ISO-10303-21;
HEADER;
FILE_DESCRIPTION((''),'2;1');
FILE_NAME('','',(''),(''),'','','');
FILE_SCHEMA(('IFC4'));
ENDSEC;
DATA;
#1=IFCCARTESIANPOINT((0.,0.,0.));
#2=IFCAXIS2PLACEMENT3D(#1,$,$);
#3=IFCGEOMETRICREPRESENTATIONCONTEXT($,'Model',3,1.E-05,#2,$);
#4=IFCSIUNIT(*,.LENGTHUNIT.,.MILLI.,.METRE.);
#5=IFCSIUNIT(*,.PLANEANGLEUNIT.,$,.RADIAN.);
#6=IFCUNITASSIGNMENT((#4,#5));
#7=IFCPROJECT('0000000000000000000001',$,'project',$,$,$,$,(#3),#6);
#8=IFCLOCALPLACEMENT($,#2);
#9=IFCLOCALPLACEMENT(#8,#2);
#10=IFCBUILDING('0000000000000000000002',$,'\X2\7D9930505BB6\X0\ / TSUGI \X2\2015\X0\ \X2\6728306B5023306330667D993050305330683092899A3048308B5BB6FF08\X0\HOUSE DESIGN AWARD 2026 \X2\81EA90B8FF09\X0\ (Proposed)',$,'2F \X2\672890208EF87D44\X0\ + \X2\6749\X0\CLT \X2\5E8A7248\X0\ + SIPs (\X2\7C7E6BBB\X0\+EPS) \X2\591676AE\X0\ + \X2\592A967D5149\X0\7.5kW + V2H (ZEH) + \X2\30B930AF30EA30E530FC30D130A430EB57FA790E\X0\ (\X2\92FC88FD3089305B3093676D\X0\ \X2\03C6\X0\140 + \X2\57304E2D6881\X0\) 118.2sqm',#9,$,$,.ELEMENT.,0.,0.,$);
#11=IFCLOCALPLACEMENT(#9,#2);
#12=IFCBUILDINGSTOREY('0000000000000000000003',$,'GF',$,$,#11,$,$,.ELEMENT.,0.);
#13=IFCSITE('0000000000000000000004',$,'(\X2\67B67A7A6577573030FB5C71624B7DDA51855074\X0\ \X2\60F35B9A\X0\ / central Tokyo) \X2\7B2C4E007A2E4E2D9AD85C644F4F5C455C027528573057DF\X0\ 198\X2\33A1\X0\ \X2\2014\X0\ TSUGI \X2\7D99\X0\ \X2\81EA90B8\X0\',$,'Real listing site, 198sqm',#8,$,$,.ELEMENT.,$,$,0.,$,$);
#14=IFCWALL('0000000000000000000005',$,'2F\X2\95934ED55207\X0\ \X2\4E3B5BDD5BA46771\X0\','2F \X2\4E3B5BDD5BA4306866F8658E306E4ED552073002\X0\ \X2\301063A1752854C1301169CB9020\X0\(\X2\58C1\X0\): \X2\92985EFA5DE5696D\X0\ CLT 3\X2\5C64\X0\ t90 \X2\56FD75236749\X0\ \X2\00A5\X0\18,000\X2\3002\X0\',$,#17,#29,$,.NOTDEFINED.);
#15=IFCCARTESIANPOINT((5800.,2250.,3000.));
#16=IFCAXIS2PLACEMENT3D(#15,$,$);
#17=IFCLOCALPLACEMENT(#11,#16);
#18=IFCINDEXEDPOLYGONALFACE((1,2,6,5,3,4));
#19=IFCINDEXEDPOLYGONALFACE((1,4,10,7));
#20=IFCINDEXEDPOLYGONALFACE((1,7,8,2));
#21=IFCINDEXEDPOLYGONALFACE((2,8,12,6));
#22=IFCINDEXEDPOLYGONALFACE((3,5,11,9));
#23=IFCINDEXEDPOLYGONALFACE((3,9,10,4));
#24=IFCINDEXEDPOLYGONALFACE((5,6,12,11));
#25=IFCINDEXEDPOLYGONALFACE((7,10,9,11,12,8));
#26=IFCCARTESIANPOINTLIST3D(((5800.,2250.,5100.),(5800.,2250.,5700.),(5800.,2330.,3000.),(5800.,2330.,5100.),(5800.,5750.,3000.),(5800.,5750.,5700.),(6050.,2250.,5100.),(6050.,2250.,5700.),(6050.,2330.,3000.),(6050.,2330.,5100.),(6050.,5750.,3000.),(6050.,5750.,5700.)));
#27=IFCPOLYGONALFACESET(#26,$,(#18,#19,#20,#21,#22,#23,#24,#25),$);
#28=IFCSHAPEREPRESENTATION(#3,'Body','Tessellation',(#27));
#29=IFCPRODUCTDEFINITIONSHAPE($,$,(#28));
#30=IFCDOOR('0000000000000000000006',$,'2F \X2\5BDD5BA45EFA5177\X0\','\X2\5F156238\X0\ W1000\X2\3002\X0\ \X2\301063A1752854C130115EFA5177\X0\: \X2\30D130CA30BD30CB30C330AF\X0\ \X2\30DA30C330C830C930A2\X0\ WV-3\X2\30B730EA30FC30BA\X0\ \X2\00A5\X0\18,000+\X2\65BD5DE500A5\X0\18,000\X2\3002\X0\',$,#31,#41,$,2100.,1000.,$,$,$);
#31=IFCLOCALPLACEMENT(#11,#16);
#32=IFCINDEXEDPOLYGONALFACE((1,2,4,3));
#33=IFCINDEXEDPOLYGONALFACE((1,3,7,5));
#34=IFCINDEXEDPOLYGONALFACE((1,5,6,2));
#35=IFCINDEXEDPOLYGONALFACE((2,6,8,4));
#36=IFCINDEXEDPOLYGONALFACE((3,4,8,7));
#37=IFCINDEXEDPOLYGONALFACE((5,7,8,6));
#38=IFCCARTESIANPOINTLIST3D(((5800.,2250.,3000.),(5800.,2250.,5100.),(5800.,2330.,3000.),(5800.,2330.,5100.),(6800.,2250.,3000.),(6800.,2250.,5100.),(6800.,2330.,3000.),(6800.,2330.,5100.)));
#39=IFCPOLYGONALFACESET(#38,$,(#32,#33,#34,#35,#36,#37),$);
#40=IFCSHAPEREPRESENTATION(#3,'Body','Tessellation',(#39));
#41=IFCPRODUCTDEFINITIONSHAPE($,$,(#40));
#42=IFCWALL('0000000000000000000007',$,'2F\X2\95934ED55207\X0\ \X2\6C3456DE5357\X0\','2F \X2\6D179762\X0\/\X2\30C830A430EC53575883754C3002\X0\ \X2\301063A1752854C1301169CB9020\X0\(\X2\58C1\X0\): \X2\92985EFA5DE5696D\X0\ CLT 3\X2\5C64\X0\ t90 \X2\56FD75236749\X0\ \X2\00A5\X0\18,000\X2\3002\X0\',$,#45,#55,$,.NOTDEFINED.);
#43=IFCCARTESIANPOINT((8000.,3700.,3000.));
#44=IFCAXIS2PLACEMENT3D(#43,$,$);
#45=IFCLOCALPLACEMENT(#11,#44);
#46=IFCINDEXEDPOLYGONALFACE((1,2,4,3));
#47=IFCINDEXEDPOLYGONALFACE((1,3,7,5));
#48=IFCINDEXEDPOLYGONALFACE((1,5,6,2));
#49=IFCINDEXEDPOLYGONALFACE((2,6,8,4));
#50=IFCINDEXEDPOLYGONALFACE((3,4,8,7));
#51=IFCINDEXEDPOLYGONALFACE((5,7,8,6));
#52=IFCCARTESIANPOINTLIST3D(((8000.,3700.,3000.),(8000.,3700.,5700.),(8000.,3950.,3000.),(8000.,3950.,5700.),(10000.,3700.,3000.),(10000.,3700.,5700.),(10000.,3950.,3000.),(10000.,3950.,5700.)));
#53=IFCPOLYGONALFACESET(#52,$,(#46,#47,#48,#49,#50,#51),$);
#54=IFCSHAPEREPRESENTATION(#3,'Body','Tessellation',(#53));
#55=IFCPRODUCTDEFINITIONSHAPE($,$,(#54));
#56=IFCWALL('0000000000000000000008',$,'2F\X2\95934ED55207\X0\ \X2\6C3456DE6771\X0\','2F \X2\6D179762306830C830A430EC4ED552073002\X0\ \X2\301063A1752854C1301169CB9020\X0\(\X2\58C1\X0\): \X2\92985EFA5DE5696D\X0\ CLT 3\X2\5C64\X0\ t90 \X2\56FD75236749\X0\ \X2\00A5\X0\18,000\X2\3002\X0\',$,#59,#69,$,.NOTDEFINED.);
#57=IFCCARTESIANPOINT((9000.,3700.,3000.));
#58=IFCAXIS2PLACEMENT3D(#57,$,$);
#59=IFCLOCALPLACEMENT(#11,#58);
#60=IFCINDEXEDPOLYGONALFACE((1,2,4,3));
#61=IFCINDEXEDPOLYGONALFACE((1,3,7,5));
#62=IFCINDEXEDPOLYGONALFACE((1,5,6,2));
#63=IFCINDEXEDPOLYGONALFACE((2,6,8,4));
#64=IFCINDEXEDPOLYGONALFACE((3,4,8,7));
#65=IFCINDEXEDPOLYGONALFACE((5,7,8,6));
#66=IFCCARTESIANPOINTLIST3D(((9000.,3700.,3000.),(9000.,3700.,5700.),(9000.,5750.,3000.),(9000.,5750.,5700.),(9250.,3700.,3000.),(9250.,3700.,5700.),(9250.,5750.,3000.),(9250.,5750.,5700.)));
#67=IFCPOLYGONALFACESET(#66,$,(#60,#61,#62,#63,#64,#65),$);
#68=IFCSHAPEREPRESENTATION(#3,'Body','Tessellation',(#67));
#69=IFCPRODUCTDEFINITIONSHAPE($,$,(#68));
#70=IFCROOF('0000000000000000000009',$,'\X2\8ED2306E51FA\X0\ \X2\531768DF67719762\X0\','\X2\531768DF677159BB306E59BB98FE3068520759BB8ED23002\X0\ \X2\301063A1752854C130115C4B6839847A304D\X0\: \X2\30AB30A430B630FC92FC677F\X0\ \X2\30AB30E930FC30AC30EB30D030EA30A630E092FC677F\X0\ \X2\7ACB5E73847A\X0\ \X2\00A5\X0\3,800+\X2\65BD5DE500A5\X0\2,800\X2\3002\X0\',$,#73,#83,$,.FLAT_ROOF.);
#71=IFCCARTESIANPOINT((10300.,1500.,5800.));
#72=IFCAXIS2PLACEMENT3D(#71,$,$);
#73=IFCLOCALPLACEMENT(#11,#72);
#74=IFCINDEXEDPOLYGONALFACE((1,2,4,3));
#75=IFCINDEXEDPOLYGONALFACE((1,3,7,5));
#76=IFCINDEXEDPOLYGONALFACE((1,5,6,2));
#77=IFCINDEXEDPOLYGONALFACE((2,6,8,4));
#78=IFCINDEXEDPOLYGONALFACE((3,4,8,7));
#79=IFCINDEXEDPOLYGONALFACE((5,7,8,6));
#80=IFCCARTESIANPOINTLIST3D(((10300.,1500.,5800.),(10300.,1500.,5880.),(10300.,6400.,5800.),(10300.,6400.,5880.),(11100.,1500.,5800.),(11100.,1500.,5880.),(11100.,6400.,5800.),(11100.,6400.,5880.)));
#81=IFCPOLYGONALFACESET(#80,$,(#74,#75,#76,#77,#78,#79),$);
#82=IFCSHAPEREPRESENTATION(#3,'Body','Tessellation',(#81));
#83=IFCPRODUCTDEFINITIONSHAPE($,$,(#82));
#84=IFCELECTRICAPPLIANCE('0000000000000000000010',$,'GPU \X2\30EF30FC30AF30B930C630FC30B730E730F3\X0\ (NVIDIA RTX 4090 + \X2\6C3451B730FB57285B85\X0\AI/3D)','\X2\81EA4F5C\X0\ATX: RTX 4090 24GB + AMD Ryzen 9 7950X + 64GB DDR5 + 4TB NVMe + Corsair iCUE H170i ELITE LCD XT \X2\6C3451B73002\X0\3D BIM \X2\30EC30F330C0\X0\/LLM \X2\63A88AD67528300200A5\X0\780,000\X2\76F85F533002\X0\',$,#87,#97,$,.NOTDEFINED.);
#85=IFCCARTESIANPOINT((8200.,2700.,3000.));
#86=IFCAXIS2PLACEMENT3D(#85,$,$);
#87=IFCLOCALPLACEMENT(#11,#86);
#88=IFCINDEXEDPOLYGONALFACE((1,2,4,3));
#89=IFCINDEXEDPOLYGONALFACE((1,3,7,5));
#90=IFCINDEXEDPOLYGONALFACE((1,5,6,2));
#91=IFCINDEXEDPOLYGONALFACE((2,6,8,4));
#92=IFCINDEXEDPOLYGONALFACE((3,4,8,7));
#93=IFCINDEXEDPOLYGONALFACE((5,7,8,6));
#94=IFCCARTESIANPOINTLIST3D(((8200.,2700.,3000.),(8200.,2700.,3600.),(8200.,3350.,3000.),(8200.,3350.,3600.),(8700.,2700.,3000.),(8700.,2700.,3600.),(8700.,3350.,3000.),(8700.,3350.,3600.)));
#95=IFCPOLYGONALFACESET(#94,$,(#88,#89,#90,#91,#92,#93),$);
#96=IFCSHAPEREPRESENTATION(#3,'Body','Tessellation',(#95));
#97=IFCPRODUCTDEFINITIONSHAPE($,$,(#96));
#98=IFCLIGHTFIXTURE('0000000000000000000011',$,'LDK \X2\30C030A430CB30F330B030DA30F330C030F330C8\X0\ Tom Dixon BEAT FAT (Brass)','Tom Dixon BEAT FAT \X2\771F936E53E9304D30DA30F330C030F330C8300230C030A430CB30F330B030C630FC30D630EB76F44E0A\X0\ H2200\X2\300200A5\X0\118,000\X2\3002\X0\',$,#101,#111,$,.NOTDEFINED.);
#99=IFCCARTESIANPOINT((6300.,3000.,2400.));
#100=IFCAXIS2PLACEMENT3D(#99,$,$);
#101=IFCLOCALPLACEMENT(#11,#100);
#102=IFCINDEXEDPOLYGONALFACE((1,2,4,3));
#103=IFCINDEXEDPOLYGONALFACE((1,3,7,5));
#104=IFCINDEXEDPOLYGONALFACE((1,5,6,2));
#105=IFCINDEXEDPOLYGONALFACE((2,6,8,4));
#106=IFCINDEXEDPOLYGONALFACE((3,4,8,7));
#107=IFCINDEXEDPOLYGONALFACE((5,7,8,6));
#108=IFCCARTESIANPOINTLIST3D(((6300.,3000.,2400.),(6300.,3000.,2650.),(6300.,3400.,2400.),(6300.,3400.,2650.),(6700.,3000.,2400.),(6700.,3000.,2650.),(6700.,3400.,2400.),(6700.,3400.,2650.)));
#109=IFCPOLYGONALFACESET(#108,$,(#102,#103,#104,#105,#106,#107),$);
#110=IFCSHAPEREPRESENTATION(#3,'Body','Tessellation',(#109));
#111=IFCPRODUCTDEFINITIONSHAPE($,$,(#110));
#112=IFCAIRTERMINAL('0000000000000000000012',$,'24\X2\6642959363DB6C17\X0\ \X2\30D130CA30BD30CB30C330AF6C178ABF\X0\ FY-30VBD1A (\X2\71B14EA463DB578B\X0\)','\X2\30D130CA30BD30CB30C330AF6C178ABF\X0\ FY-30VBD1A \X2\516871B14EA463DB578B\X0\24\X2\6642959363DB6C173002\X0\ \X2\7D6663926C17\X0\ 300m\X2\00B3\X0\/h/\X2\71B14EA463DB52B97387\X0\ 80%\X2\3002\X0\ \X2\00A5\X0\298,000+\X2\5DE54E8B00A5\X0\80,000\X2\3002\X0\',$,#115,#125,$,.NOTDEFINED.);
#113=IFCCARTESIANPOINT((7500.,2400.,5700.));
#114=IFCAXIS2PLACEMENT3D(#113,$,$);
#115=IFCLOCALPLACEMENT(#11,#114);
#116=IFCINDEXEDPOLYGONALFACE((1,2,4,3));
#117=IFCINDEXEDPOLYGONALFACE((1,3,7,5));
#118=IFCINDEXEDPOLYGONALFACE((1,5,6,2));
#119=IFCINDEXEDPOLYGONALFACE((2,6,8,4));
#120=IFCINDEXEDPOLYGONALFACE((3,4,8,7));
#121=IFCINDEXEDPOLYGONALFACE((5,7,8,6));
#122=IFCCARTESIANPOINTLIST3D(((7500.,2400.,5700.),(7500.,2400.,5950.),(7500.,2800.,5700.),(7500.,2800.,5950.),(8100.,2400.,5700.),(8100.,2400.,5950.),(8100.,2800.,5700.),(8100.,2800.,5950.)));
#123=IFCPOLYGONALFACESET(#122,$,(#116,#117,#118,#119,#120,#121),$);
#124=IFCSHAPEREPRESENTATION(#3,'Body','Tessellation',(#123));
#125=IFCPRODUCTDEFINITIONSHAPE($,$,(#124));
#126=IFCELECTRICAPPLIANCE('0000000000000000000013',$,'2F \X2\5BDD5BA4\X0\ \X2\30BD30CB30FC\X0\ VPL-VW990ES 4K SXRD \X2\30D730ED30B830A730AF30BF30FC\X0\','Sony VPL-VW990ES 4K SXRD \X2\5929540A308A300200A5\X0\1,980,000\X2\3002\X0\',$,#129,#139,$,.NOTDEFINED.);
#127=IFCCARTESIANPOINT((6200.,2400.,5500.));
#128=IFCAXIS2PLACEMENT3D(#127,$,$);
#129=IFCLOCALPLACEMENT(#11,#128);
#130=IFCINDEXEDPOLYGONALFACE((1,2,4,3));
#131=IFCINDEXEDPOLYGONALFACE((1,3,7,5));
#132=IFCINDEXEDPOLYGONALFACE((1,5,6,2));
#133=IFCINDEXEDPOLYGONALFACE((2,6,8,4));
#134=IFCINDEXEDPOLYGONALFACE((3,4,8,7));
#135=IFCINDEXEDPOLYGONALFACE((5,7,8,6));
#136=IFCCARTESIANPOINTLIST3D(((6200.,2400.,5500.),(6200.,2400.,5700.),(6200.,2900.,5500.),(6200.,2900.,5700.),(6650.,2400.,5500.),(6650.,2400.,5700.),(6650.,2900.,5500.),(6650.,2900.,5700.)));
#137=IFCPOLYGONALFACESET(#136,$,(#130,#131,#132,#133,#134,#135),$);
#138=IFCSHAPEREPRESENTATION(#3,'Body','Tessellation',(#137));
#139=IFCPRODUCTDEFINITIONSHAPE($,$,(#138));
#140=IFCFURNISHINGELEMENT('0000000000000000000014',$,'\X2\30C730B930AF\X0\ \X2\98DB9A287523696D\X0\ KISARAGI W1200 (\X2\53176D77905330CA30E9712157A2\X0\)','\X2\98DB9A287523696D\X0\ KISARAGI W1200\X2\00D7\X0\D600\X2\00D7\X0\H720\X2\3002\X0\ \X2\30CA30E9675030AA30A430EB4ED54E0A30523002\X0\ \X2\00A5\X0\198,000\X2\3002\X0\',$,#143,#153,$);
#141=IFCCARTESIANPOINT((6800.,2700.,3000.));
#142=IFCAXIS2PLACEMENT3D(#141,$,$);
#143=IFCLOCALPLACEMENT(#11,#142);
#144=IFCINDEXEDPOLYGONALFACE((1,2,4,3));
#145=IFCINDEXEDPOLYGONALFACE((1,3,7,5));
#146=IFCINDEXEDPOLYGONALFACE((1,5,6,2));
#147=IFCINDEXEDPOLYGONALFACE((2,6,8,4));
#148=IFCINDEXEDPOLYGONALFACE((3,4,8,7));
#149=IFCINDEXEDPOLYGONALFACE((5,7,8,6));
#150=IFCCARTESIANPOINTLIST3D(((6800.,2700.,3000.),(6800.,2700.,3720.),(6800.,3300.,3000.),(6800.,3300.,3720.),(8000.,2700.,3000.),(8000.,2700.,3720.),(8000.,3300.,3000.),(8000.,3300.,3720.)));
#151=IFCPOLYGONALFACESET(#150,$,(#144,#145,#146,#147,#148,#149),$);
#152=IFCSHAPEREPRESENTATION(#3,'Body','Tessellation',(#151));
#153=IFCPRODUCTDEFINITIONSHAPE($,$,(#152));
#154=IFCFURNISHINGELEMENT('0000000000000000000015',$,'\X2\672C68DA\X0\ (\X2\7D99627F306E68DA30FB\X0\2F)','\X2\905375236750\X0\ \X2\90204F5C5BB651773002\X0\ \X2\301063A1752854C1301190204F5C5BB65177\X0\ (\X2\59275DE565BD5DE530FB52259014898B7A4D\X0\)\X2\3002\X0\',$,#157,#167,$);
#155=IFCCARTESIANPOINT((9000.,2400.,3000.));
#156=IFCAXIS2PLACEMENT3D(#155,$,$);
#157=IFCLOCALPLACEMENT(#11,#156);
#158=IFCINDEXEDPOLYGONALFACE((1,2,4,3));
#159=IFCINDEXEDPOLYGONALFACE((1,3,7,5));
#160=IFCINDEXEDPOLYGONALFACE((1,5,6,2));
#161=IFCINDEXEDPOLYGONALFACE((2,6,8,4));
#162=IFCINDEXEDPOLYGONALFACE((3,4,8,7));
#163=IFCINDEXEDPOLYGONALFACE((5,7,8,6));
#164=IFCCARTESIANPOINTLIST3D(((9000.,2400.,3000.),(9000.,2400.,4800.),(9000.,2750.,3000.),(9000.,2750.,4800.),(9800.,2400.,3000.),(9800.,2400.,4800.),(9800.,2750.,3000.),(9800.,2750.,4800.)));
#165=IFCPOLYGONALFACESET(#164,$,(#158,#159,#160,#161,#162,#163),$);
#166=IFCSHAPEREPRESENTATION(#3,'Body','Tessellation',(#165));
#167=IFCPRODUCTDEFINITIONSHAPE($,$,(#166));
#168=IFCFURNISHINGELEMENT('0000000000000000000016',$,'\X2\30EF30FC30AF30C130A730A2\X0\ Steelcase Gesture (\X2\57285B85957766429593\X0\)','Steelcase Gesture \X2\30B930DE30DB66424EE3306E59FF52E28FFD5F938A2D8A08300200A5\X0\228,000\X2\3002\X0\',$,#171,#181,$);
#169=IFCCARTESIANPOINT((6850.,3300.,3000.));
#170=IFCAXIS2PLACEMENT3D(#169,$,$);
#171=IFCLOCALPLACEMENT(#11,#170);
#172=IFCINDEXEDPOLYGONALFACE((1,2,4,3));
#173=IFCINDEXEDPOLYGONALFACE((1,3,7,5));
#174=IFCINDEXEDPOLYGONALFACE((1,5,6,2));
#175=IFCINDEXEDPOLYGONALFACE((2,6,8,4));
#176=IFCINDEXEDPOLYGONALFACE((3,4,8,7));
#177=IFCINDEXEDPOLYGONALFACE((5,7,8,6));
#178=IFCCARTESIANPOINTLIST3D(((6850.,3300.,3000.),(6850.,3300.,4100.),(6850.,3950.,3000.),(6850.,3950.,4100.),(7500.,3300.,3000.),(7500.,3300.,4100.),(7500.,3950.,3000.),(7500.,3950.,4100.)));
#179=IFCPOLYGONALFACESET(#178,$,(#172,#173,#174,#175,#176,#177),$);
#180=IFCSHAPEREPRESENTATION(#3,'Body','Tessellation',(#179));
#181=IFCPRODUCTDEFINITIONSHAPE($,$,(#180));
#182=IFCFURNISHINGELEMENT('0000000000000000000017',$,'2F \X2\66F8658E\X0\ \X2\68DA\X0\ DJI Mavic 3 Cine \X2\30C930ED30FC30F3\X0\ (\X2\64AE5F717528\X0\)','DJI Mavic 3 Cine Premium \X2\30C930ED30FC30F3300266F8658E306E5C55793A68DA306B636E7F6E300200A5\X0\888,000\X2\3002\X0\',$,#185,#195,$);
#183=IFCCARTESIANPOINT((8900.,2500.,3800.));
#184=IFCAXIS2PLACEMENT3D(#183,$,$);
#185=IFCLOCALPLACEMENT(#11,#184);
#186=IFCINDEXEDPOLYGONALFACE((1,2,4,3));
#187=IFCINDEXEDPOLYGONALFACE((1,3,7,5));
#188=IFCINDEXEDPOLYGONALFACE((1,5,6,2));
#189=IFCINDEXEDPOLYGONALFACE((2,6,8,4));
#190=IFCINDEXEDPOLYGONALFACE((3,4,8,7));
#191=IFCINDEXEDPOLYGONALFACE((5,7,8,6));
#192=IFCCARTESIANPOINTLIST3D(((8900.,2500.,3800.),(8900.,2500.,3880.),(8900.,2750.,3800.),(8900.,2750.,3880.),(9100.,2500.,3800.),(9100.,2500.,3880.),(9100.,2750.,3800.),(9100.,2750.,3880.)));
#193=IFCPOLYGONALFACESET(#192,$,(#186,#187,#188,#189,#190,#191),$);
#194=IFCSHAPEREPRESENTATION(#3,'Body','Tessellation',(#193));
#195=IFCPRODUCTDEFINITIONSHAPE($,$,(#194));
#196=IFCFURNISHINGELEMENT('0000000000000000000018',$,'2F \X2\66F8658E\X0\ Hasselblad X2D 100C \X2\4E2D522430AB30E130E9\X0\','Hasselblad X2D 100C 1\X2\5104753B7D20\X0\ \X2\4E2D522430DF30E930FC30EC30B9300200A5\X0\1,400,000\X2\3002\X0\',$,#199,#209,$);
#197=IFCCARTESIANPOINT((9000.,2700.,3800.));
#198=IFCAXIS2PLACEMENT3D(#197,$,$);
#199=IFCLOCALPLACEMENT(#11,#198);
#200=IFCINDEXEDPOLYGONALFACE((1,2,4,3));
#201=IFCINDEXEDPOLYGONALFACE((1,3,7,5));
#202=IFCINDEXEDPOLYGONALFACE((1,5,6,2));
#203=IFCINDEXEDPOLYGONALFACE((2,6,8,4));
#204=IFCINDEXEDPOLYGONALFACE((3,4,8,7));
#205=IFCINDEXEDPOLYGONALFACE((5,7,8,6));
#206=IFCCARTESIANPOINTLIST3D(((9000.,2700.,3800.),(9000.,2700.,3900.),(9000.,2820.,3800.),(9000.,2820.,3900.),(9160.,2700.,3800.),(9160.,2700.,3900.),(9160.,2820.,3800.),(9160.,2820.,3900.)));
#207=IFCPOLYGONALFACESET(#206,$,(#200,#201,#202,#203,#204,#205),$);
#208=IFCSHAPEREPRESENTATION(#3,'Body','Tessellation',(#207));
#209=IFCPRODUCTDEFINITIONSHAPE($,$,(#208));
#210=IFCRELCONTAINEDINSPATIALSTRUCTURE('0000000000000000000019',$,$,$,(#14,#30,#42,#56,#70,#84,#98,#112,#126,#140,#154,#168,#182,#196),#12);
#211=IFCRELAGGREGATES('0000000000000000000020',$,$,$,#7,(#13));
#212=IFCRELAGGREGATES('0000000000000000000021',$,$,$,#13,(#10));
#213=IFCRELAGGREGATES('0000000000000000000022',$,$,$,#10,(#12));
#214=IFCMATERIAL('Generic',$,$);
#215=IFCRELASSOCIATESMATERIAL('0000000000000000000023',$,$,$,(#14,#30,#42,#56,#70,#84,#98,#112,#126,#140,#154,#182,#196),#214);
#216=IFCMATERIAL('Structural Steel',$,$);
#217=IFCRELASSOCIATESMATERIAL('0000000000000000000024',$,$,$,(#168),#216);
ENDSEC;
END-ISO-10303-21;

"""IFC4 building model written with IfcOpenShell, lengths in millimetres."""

from ifc_helpers import new_model, si_unit, frame, frame_2d, origin, place, context, project, spatial, rectangle, extrude, material, element, fill, save


model = new_model("IFC4")

# Units and contexts
model_context = context("Model", 3, precision=1e-05, world=origin())
ifc_project = project(units=[si_unit("LENGTHUNIT", "METRE", prefix="MILLI"), si_unit("PLANEANGLEUNIT", "RADIAN")], contexts=[model_context])

# Site, building, storey
site_placement = place(None, origin())
site = spatial("IfcSite", under=ifc_project, at=site_placement, Name="(架空敷地・山手線内側 想定 / central Tokyo) 第一種中高層住居専用地域 198㎡ — TSUGI 継 自邸", ObjectType="Real listing site, 198sqm", CompositionType="ELEMENT", RefElevation=0.0)
building_placement = place(site_placement, origin())
building = spatial("IfcBuilding", under=site, at=building_placement, Name="継ぐ家 / TSUGI ― 木に倣って継ぐことを覚える家（HOUSE DESIGN AWARD 2026 自邸） (Proposed)", ObjectType="2F 木造軸組 + 杉CLT 床版 + SIPs (籾殻+EPS) 外皮 + 太陽光7.5kW + V2H (ZEH) + スクリューパイル基礎 (鋼製らせん杭 φ140 + 地中梁) 118.2sqm", CompositionType="ELEMENT", ElevationOfRefHeight=0.0, ElevationOfTerrain=0.0)
storey_placement = place(building_placement, origin())
storey = spatial("IfcBuildingStorey", under=building, at=storey_placement, Name="GF", CompositionType="ELEMENT", Elevation=0.0)

# Shared definitions
ifc_material_1 = material(Name="Generic")

# Wall, opening, door
wall_1_placement = place(storey_placement, frame((5800.0, 2250.0, 3000.0)))
wall_1 = element("IfcWall", 1, at=wall_1_placement, inside=storey, material=ifc_material_1, Name="2F間仕切 主寝室東", Description="2F 主寝室と書斎の仕切。 【採用品】構造(壁): 銘建工業 CLT 3層 t90 国産杉 ¥18,000。", PredefinedType="NOTDEFINED", context=model_context, shape_type="SweptSolid", body=[
    extrude(rectangle(XDim=250.0, YDim=3500.0, at=frame_2d((125.0, 1750.0))), frame((5800.0, 2250.0, 3000.0)), (0.0, 0.0, 1.0), 2700.0),
])
opening_placement = place(storey_placement, frame((5800.0, 2250.0, 3000.0)))
opening = element("IfcOpeningElement", 2, at=opening_placement, cuts=wall_1, PredefinedType="NOTDEFINED", context=model_context, shape_type="SweptSolid", body=[
    extrude(rectangle(XDim=1000.0, YDim=80.0, at=frame_2d((500.0, 40.0))), frame((5800.0, 2250.0, 3000.0)), (0.0, 0.0, 1.0), 2100.0),
])
door_placement = place(storey_placement, frame((5800.0, 2250.0, 3000.0)))
door = element("IfcDoor", 3, at=door_placement, inside=storey, material=ifc_material_1, Name="2F 寝室建具", Description="引戸 W1000。 【採用品】建具: パナソニック ペットドア WV-3シリーズ ¥18,000+施工¥18,000。", OverallHeight=2100.0, OverallWidth=1000.0, context=model_context, shape_type="SweptSolid", body=[
    extrude(rectangle(XDim=1000.0, YDim=80.0, at=frame_2d((500.0, 40.0))), frame((5800.0, 2250.0, 3000.0)), (0.0, 0.0, 1.0), 2100.0),
])
fill(opening, door)

# Walls
wall_2_placement = place(storey_placement, frame((8000.0, 3700.0, 3000.0)))
element("IfcWall", 4, at=wall_2_placement, inside=storey, material=ifc_material_1, Name="2F間仕切 水回南", Description="2F 洗面/トイレ南境界。 【採用品】構造(壁): 銘建工業 CLT 3層 t90 国産杉 ¥18,000。", PredefinedType="NOTDEFINED", context=model_context, shape_type="SweptSolid", body=[
    extrude(rectangle(XDim=2000.0, YDim=250.0, at=frame_2d((1000.0, 125.0))), frame((8000.0, 3700.0, 3000.0)), (0.0, 0.0, 1.0), 2700.0),
])
wall_3_placement = place(storey_placement, frame((9000.0, 3700.0, 3000.0)))
element("IfcWall", 5, at=wall_3_placement, inside=storey, material=ifc_material_1, Name="2F間仕切 水回東", Description="2F 洗面とトイレ仕切。 【採用品】構造(壁): 銘建工業 CLT 3層 t90 国産杉 ¥18,000。", PredefinedType="NOTDEFINED", context=model_context, shape_type="SweptSolid", body=[
    extrude(rectangle(XDim=250.0, YDim=2050.0, at=frame_2d((125.0, 1025.0))), frame((9000.0, 3700.0, 3000.0)), (0.0, 0.0, 1.0), 2700.0),
])

# Roof
roof_placement = place(storey_placement, frame((10300.0, 1500.0, 5800.0)))
element("IfcRoof", 6, at=roof_placement, inside=storey, material=ifc_material_1, Name="軒の出 北棟東面", Description="北棟東妻の妻飾と切妻軒。 【採用品】屋根葺き: カイザー鋼板 カラーガルバリウム鋼板 立平葺 ¥3,800+施工¥2,800。", PredefinedType="FLAT_ROOF", context=model_context, shape_type="SweptSolid", body=[
    extrude(rectangle(XDim=800.0, YDim=4900.0, at=frame_2d((400.0, 2450.0))), frame((10300.0, 1500.0, 5800.0)), (0.0, 0.0, 1.0), 80.0),
])

# Electric appliance
electric_appliance_1_placement = place(storey_placement, frame((8200.0, 2700.0, 3000.0)))
element("IfcElectricAppliance", 7, at=electric_appliance_1_placement, inside=storey, material=ifc_material_1, Name="GPU ワークステーション (NVIDIA RTX 4090 + 水冷・在宅AI/3D)", Description="自作ATX: RTX 4090 24GB + AMD Ryzen 9 7950X + 64GB DDR5 + 4TB NVMe + Corsair iCUE H170i ELITE LCD XT 水冷。3D BIM レンダ/LLM 推論用。¥780,000相当。", PredefinedType="NOTDEFINED", context=model_context, shape_type="SweptSolid", body=[
    extrude(rectangle(XDim=500.0, YDim=650.0, at=frame_2d((250.0, 325.0))), frame((8200.0, 2700.0, 3000.0)), (0.0, 0.0, 1.0), 600.0),
])

# Light fixture
light_fixture_placement = place(storey_placement, frame((6300.0, 3000.0, 2400.0)))
element("IfcLightFixture", 8, at=light_fixture_placement, inside=storey, material=ifc_material_1, Name="LDK ダイニングペンダント Tom Dixon BEAT FAT (Brass)", Description="Tom Dixon BEAT FAT 真鍮叩きペンダント。ダイニングテーブル直上 H2200。¥118,000。", PredefinedType="NOTDEFINED", context=model_context, shape_type="SweptSolid", body=[
    extrude(rectangle(XDim=400.0, YDim=400.0, at=frame_2d((200.0, 200.0))), frame((6300.0, 3000.0, 2400.0)), (0.0, 0.0, 1.0), 250.0),
])

# Air terminal
air_terminal_placement = place(storey_placement, frame((7500.0, 2400.0, 5700.0)))
element("IfcAirTerminal", 9, at=air_terminal_placement, inside=storey, material=ifc_material_1, Name="24時間換気 パナソニック気調 FY-30VBD1A (熱交換型)", Description="パナソニック気調 FY-30VBD1A 全熱交換型24時間換気。 給排気 300m³/h/熱交換効率 80%。 ¥298,000+工事¥80,000。", PredefinedType="NOTDEFINED", context=model_context, shape_type="SweptSolid", body=[
    extrude(rectangle(XDim=600.0, YDim=400.0, at=frame_2d((300.0, 200.0))), frame((7500.0, 2400.0, 5700.0)), (0.0, 0.0, 1.0), 250.0),
])

# Electric appliance
electric_appliance_2_placement = place(storey_placement, frame((6200.0, 2400.0, 5500.0)))
element("IfcElectricAppliance", 10, at=electric_appliance_2_placement, inside=storey, material=ifc_material_1, Name="2F 寝室 ソニー VPL-VW990ES 4K SXRD プロジェクター", Description="Sony VPL-VW990ES 4K SXRD 天吊り。¥1,980,000。", PredefinedType="NOTDEFINED", context=model_context, shape_type="SweptSolid", body=[
    extrude(rectangle(XDim=450.0, YDim=500.0, at=frame_2d((225.0, 250.0))), frame((6200.0, 2400.0, 5500.0)), (0.0, 0.0, 1.0), 200.0),
])

# Furnishing elements
furnishing_1_placement = place(storey_placement, frame((6800.0, 2700.0, 3000.0)))
element("IfcFurnishingElement", 11, at=furnishing_1_placement, inside=storey, material=ifc_material_1, Name="デスク 飛騨産業 KISARAGI W1200 (北海道ナラ無垢)", Description="飛騨産業 KISARAGI W1200×D600×H720。 ナラ材オイル仕上げ。 ¥198,000。", context=model_context, shape_type="SweptSolid", body=[
    extrude(rectangle(XDim=1200.0, YDim=600.0, at=frame_2d((600.0, 300.0))), frame((6800.0, 2700.0, 3000.0)), (0.0, 0.0, 1.0), 720.0),
])
furnishing_2_placement = place(storey_placement, frame((9000.0, 2400.0, 3000.0)))
element("IfcFurnishingElement", 12, at=furnishing_2_placement, inside=storey, material=ifc_material_1, Name="本棚 (継承の棚・2F)", Description="道産材 造作家具。 【採用品】造作家具 (大工施工・別途見積)。", context=model_context, shape_type="SweptSolid", body=[
    extrude(rectangle(XDim=800.0, YDim=350.0, at=frame_2d((400.0, 175.0))), frame((9000.0, 2400.0, 3000.0)), (0.0, 0.0, 1.0), 1800.0),
])
ifc_material_2 = material(Name="Structural Steel")
furnishing_3_placement = place(storey_placement, frame((6850.0, 3300.0, 3000.0)))
element("IfcFurnishingElement", 13, at=furnishing_3_placement, inside=storey, material=ifc_material_2, Name="ワークチェア Steelcase Gesture (在宅長時間)", Description="Steelcase Gesture スマホ時代の姿勢追従設計。¥228,000。", context=model_context, shape_type="SweptSolid", body=[
    extrude(rectangle(XDim=650.0, YDim=650.0, at=frame_2d((325.0, 325.0))), frame((6850.0, 3300.0, 3000.0)), (0.0, 0.0, 1.0), 1100.0),
])
furnishing_4_placement = place(storey_placement, frame((8900.0, 2500.0, 3800.0)))
element("IfcFurnishingElement", 14, at=furnishing_4_placement, inside=storey, material=ifc_material_1, Name="2F 書斎 棚 DJI Mavic 3 Cine ドローン (撮影用)", Description="DJI Mavic 3 Cine Premium ドローン。書斎の展示棚に据置。¥888,000。", context=model_context, shape_type="SweptSolid", body=[
    extrude(rectangle(XDim=200.0, YDim=250.0, at=frame_2d((100.0, 125.0))), frame((8900.0, 2500.0, 3800.0)), (0.0, 0.0, 1.0), 80.0),
])
furnishing_5_placement = place(storey_placement, frame((9000.0, 2700.0, 3800.0)))
element("IfcFurnishingElement", 15, at=furnishing_5_placement, inside=storey, material=ifc_material_1, Name="2F 書斎 Hasselblad X2D 100C 中判カメラ", Description="Hasselblad X2D 100C 1億画素 中判ミラーレス。¥1,400,000。", context=model_context, shape_type="SweptSolid", body=[
    extrude(rectangle(XDim=160.0, YDim=120.0, at=frame_2d((80.0, 60.0))), frame((9000.0, 2700.0, 3800.0)), (0.0, 0.0, 1.0), 100.0),
])

save(model, "model.ifc")
